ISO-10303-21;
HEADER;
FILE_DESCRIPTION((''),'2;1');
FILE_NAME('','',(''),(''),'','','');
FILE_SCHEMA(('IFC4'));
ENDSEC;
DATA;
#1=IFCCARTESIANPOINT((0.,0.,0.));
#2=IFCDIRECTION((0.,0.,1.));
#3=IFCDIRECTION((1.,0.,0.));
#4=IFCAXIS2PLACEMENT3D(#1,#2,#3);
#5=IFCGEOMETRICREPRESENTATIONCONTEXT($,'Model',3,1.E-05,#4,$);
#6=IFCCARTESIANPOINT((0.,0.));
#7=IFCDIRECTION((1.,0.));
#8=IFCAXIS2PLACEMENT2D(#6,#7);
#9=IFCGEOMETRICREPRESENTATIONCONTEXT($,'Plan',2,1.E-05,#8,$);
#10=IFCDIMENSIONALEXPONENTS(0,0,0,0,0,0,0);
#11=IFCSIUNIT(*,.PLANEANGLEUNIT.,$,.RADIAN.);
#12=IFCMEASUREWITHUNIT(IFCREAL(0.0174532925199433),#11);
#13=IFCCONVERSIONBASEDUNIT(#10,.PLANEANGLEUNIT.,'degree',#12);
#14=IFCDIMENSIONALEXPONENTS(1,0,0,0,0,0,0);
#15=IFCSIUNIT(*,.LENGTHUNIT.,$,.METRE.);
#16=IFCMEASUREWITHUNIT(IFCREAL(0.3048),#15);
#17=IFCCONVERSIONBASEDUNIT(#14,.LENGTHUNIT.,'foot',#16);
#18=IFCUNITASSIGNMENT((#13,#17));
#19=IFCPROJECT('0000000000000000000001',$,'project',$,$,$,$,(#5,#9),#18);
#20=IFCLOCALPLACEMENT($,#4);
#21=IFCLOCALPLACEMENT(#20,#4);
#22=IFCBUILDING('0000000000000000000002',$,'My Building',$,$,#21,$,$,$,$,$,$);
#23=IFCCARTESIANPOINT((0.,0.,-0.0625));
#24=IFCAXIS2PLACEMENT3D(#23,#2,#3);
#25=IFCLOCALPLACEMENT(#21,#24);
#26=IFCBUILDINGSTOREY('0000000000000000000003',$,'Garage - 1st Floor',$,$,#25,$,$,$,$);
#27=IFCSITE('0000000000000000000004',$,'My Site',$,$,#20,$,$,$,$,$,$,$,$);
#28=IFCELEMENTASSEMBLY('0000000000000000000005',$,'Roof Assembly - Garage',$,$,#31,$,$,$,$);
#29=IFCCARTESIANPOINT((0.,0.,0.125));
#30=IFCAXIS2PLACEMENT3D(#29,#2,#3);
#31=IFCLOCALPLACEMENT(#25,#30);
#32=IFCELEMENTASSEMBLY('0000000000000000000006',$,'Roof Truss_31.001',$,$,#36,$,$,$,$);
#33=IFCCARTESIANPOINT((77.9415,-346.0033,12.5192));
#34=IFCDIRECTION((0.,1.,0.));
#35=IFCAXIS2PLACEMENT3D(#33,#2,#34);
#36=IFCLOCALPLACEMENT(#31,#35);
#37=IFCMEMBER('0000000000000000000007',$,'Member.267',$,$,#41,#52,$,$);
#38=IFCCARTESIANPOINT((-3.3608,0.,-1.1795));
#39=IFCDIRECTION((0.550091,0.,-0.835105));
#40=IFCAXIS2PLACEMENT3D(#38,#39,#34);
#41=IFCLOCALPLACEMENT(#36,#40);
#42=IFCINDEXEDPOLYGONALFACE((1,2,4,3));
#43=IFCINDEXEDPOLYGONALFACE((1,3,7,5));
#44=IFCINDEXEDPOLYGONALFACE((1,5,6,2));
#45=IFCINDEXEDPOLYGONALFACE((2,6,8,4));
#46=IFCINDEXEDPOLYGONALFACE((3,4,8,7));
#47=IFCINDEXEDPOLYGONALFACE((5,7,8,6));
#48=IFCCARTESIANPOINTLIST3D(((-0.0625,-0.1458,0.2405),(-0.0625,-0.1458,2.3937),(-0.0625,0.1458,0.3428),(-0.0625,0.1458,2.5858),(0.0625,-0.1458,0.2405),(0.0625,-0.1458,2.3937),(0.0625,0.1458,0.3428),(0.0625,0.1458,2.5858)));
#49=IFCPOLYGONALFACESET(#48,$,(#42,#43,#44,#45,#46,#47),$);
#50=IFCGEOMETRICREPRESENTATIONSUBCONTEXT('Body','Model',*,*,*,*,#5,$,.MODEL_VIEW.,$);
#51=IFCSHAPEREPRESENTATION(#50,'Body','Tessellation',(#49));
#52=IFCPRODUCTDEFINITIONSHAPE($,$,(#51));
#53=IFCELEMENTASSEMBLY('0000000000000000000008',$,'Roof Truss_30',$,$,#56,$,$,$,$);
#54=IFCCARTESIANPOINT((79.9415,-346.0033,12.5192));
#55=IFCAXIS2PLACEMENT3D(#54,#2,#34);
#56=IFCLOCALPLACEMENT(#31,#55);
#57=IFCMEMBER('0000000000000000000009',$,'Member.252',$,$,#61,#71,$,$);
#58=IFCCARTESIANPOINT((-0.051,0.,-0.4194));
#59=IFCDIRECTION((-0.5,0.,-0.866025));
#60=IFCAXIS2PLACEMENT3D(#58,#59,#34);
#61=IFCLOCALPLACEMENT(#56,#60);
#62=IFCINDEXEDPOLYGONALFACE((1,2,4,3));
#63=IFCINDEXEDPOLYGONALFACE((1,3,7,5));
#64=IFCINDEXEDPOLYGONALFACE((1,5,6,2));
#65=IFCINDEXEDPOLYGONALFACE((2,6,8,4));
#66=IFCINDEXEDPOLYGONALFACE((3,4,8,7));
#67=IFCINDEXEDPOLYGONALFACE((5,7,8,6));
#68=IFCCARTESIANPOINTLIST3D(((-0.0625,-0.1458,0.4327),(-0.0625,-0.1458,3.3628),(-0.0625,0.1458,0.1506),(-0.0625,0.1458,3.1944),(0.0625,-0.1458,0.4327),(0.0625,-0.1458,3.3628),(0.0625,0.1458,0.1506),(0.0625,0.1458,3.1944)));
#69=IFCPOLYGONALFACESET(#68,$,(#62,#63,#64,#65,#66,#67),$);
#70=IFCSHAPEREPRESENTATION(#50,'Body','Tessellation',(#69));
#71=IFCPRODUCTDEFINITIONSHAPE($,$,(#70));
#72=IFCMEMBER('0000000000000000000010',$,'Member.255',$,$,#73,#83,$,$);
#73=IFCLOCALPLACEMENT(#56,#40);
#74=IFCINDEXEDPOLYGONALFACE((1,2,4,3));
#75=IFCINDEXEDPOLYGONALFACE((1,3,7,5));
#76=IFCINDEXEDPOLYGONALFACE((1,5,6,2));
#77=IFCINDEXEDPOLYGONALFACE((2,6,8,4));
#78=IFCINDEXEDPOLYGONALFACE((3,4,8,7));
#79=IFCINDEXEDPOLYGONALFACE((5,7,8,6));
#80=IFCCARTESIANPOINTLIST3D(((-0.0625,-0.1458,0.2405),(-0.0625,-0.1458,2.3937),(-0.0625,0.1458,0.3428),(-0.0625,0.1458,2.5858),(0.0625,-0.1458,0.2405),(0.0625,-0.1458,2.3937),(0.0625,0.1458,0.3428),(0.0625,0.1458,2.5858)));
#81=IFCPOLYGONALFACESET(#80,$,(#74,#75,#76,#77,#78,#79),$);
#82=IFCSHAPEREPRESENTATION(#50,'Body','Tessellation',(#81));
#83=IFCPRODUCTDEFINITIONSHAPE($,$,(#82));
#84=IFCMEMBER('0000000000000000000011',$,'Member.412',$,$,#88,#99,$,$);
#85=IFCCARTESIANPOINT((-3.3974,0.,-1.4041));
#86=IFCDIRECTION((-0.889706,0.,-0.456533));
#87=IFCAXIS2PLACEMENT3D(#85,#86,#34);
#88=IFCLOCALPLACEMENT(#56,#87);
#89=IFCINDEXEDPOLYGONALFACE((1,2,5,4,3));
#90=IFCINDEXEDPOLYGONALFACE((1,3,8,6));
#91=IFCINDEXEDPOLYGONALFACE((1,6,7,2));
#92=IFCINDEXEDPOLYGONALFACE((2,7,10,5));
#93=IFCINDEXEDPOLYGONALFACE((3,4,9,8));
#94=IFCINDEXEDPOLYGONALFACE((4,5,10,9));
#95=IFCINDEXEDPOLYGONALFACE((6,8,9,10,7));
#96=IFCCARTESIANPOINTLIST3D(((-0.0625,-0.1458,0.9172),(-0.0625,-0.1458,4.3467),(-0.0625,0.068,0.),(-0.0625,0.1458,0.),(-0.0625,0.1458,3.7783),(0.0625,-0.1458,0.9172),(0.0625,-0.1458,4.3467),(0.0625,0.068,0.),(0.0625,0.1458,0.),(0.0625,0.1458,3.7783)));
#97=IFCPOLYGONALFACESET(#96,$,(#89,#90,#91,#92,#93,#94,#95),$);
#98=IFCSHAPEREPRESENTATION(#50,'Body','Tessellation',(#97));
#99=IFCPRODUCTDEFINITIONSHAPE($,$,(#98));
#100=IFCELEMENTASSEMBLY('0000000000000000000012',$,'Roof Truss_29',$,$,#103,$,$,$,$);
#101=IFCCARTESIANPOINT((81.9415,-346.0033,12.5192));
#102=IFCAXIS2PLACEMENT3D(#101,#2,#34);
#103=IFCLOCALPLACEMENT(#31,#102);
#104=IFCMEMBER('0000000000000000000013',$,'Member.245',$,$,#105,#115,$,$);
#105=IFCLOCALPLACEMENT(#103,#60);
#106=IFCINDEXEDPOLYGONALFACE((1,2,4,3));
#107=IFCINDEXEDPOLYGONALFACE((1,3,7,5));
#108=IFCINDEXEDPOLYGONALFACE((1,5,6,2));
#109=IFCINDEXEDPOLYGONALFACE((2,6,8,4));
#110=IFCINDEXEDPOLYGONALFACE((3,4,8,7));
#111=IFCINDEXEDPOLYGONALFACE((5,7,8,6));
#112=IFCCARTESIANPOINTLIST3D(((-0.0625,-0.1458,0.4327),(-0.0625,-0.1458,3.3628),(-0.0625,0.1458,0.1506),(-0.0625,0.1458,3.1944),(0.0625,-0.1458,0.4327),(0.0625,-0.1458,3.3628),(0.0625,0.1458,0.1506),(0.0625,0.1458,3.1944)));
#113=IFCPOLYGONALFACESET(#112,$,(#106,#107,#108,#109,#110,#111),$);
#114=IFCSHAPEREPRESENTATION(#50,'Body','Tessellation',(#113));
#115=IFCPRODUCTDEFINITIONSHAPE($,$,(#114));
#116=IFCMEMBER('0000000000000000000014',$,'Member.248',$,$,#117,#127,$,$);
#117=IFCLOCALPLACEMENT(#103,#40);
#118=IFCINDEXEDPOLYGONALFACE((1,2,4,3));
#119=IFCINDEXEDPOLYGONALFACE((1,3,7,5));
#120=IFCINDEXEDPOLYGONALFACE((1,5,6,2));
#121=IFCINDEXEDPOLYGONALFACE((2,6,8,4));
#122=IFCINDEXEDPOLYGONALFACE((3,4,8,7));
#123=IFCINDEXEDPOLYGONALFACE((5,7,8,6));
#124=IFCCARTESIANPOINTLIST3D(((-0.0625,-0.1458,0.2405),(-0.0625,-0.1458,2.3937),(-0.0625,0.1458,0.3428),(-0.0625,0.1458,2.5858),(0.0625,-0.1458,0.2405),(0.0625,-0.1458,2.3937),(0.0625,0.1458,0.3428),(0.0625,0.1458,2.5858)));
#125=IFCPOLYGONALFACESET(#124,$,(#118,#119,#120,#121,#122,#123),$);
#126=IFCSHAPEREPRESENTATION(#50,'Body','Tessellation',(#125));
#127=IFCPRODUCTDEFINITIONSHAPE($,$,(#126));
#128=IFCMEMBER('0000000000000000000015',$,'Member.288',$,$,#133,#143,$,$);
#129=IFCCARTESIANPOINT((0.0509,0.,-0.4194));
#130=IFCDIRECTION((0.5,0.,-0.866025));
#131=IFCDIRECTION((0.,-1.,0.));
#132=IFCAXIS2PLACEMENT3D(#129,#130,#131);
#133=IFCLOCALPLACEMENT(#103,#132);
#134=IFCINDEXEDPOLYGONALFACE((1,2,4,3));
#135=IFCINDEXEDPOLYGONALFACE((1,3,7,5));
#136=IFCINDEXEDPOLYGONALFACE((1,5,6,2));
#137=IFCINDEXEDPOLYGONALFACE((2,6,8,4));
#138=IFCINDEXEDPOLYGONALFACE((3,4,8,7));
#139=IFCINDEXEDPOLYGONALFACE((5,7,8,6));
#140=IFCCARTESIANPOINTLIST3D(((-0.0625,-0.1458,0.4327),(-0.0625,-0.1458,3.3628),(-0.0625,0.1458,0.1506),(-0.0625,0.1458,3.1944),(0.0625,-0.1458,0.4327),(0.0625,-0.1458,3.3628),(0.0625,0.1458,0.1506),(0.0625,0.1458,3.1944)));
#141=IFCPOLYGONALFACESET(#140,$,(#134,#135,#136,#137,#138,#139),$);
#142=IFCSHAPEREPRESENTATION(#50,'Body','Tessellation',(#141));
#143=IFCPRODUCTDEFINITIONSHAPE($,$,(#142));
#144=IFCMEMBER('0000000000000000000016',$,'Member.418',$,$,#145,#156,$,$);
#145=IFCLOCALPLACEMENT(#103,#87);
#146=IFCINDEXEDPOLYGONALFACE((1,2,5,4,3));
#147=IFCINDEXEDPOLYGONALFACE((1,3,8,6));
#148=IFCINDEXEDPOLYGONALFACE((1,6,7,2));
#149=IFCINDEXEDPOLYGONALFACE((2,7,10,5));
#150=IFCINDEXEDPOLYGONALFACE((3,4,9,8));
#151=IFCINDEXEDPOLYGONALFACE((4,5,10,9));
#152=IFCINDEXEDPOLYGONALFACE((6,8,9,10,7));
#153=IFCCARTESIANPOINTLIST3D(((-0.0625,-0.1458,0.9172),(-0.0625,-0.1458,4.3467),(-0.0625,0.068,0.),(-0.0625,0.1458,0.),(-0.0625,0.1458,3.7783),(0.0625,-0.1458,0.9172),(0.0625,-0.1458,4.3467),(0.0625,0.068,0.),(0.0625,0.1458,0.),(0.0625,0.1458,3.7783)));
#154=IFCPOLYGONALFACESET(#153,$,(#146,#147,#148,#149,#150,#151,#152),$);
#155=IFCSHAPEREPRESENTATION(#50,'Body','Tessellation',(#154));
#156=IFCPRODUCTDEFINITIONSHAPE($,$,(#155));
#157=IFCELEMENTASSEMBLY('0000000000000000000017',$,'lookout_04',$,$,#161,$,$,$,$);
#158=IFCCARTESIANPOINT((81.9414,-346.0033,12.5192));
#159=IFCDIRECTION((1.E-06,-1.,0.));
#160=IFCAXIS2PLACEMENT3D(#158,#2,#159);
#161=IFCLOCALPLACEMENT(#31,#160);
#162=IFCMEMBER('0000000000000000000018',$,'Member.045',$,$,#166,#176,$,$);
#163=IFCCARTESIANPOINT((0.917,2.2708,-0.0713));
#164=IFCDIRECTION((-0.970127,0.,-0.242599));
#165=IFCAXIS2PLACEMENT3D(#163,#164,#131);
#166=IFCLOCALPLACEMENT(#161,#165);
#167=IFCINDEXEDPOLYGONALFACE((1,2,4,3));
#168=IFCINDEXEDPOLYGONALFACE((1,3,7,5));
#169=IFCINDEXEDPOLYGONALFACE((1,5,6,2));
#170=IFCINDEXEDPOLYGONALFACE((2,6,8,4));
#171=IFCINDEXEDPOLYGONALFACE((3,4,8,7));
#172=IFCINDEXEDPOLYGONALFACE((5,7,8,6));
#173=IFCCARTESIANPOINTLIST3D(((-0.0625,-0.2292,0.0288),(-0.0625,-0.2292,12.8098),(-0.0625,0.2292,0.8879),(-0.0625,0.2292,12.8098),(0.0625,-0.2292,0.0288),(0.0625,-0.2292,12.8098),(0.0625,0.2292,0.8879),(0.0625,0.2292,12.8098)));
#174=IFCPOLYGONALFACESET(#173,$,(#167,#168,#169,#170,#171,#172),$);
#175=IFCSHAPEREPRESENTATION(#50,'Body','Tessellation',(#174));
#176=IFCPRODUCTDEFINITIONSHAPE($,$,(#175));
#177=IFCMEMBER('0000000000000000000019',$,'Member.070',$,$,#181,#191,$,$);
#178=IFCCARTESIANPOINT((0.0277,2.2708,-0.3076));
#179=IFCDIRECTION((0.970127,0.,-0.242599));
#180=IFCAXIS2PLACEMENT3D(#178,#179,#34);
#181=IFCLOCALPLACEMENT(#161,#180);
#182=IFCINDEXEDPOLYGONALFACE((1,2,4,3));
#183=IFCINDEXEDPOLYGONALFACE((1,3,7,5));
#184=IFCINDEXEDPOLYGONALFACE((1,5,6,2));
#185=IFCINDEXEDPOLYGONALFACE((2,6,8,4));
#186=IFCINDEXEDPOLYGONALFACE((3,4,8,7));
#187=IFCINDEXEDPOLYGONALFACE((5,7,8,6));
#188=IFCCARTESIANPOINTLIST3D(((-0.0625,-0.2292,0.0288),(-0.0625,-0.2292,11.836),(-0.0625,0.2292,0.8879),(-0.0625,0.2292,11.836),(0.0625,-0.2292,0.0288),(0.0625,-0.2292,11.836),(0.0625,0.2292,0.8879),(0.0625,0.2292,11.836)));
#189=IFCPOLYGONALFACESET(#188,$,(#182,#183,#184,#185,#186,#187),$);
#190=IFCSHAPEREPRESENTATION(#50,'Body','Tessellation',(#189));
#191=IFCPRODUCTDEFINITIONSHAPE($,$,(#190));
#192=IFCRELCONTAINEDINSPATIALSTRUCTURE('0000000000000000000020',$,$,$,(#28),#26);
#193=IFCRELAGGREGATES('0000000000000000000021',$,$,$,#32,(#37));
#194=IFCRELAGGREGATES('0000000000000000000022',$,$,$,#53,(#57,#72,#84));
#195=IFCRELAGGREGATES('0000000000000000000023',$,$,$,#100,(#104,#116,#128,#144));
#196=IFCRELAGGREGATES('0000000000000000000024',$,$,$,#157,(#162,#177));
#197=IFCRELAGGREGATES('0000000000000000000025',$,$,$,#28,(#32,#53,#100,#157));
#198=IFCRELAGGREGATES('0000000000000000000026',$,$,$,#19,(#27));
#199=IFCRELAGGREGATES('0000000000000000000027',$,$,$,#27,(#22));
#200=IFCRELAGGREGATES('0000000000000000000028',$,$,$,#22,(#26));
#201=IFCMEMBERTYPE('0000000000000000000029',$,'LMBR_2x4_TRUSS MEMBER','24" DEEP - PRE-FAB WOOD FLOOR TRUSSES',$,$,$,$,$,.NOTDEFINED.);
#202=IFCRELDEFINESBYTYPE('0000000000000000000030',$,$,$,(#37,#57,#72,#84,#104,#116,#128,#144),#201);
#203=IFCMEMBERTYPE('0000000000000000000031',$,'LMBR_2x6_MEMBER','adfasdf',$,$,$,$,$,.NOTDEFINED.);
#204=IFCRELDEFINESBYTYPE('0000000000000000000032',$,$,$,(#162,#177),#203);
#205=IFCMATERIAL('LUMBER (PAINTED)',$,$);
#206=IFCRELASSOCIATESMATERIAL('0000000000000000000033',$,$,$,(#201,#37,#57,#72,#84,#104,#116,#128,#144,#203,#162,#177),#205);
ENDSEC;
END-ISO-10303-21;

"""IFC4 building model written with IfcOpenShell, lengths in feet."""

from ifc_helpers import new_model, entity, si_unit, converted_unit, frame, origin_with_axes, origin_2d_with_axis, place, context, subcontext, project, spatial, indexed_curve, outline, extrude, clip, halfspace, material, material_profile, profile_set, profile_usage, type_object, element, aggregate, save


model = new_model("IFC4")

# Units and contexts
model_context = context("Model", 3, precision=1e-05, world=origin_with_axes())
plan_context = context("Plan", 2, precision=1e-05, world=origin_2d_with_axis())
body_context = subcontext(model_context, "Body", "Model", "MODEL_VIEW")
ifc_project = project(units=[converted_unit("PLANEANGLEUNIT", "degree", entity("IfcReal", 0.0174532925199433), si_unit("PLANEANGLEUNIT", "RADIAN"), dimensions=[0, 0, 0, 0, 0, 0, 0]), converted_unit("LENGTHUNIT", "foot", entity("IfcReal", 0.3048), si_unit("LENGTHUNIT", "METRE"), dimensions=[1, 0, 0, 0, 0, 0, 0])], contexts=[model_context, plan_context])

# Site, building, storey
site_placement = place(None, origin_with_axes())
site = spatial("IfcSite", under=ifc_project, at=site_placement, Name="My Site")
building_placement = place(site_placement, origin_with_axes())
building = spatial("IfcBuilding", under=site, at=building_placement, Name="My Building")
storey_placement = place(building_placement, frame((0.0, 0.0, -0.0625), z_axis=(0.0, 0.0, 1.0), x_axis=(1.0, 0.0, 0.0)))
storey = spatial("IfcBuildingStorey", under=building, at=storey_placement, Name="Garage - 1st Floor")

# Element assemblies, members
assembly_1_placement = place(storey_placement, frame((0.0, 0.0, 0.125), z_axis=(0.0, 0.0, 1.0), x_axis=(1.0, 0.0, 0.0)))
assembly_1 = element("IfcElementAssembly", 1, at=assembly_1_placement, inside=storey, Name="Roof Assembly - Garage")
assembly_2_placement = place(assembly_1_placement, frame((77.9415, -346.0033, 12.5192), z_axis=(0.0, 0.0, 1.0), x_axis=(0.0, 1.0, 0.0)))
assembly_2 = element("IfcElementAssembly", 2, at=assembly_2_placement, Name="Roof Truss_31.001")
ifc_material_1 = material(Name="LUMBER (PAINTED)")
ifc_material_profile_1 = material_profile(ifc_material_1, outline(indexed_curve([(-0.0625, -0.1458), (0.0625, -0.1458), (0.0625, 0.1458), (-0.0625, 0.1458), (-0.0625, -0.1458)])))
ifc_profile_set_1 = profile_set([ifc_material_profile_1])
ifc_profile_usage_1 = profile_usage(ifc_profile_set_1)
member_type_1 = type_object("IfcMemberType", Name="LMBR_2x4_TRUSS MEMBER", Description="24\" DEEP - PRE-FAB WOOD FLOOR TRUSSES", PredefinedType="NOTDEFINED", material=ifc_profile_set_1)
member_1_placement = place(assembly_2_placement, frame((-3.3608, 0.0, -1.1795), z_axis=(0.550091, 0.0, -0.835105), x_axis=(0.0, 1.0, 0.0)))
member_1 = element("IfcMember", 3, at=member_1_placement, type_object=member_type_1, material=ifc_profile_usage_1, Name="Member.267", context=body_context, shape_type="Clipping", body=[
    clip(clip(extrude(outline(indexed_curve([(-0.0625, -0.1458), (0.0625, -0.1458), (0.0625, 0.1458), (-0.0625, 0.1458), (-0.0625, -0.1458)])), origin_with_axes(), (0.0, 0.0, 1.0), 2.7815), halfspace(frame((0.0, 3.2555, 1.4338), z_axis=(0.0, 0.331063, -0.943609), x_axis=(1.0, 0.0, 0.0)), False)), halfspace(frame((0.0, 7.9609, 7.7337), z_axis=(0.0, -0.550091, 0.835105), x_axis=(-1.0, 0.0, 0.0)), False)),
])
aggregate(assembly_2, [member_1])
assembly_3_placement = place(assembly_1_placement, frame((79.9415, -346.0033, 12.5192), z_axis=(0.0, 0.0, 1.0), x_axis=(0.0, 1.0, 0.0)))
assembly_3 = element("IfcElementAssembly", 4, at=assembly_3_placement, Name="Roof Truss_30")
ifc_profile_usage_2 = profile_usage(ifc_profile_set_1)
member_2_placement = place(assembly_3_placement, frame((-0.051, 0.0, -0.4194), z_axis=(-0.5, 0.0, -0.866025), x_axis=(0.0, 1.0, 0.0)))
member_2 = element("IfcMember", 5, at=member_2_placement, type_object=member_type_1, material=ifc_profile_usage_2, Name="Member.252", context=body_context, shape_type="Clipping", body=[
    clip(clip(extrude(outline(indexed_curve([(-0.0625, -0.1458), (0.0625, -0.1458), (0.0625, 0.1458), (-0.0625, 0.1458), (-0.0625, -0.1458)])), origin_with_axes(), (0.0, 0.0, 1.0), 3.5703), halfspace(frame((0.0, 0.2544, 0.0456), z_axis=(0.0, -0.69516, -0.718855), x_axis=(-1.0, 0.000001, 0.0)), False)), halfspace(frame((0.0, 7.9951, -1.3373), z_axis=(0.0, 0.5, 0.866026), x_axis=(1.0, 0.0, 0.0)), False)),
])
ifc_profile_usage_3 = profile_usage(ifc_profile_set_1)
member_3_placement = place(assembly_3_placement, frame((-3.3608, 0.0, -1.1795), z_axis=(0.550091, 0.0, -0.835105), x_axis=(0.0, 1.0, 0.0)))
member_3 = element("IfcMember", 6, at=member_3_placement, type_object=member_type_1, material=ifc_profile_usage_3, Name="Member.255", context=body_context, shape_type="Clipping", body=[
    clip(clip(extrude(outline(indexed_curve([(-0.0625, -0.1458), (0.0625, -0.1458), (0.0625, 0.1458), (-0.0625, 0.1458), (-0.0625, -0.1458)])), origin_with_axes(), (0.0, 0.0, 1.0), 2.7815), halfspace(frame((0.0, 3.2555, 1.4338), z_axis=(0.0, 0.331063, -0.943609), x_axis=(1.0, 0.0, 0.0)), False)), halfspace(frame((0.0, 7.9609, 7.7337), z_axis=(0.0, -0.550091, 0.835105), x_axis=(-1.0, 0.0, 0.0)), False)),
])
ifc_profile_usage_4 = profile_usage(ifc_profile_set_1)
member_4_placement = place(assembly_3_placement, frame((-3.3974, 0.0, -1.4041), z_axis=(-0.889706, 0.0, -0.456533), x_axis=(0.0, 1.0, 0.0)))
member_4 = element("IfcMember", 7, at=member_4_placement, type_object=member_type_1, material=ifc_profile_usage_4, Name="Member.412", context=body_context, shape_type="Clipping", body=[
    clip(clip(extrude(outline(indexed_curve([(-0.0625, -0.1458), (0.0625, -0.1458), (0.0625, 0.1458), (-0.0625, 0.1458), (-0.0625, -0.1458)])), origin_with_axes(), (0.0, 0.0, 1.0), 4.3542), halfspace(frame((0.0, 6.6441, -8.8858), z_axis=(0.0, 0.889707, 0.456533), x_axis=(1.0, 0.0, 0.0)), False)), halfspace(frame((0.0, 0.8902, -3.5265), z_axis=(-0.000001, -0.973882, -0.227053), x_axis=(-1.0, 0.000001, 0.0)), False)),
])
assembly_4_placement = place(assembly_1_placement, frame((81.9415, -346.0033, 12.5192), z_axis=(0.0, 0.0, 1.0), x_axis=(0.0, 1.0, 0.0)))
assembly_4 = element("IfcElementAssembly", 8, at=assembly_4_placement, Name="Roof Truss_29")
ifc_profile_usage_5 = profile_usage(ifc_profile_set_1)
member_5_placement = place(assembly_4_placement, frame((-0.051, 0.0, -0.4194), z_axis=(-0.5, 0.0, -0.866025), x_axis=(0.0, 1.0, 0.0)))
member_5 = element("IfcMember", 9, at=member_5_placement, type_object=member_type_1, material=ifc_profile_usage_5, Name="Member.245", context=body_context, shape_type="Clipping", body=[
    clip(clip(extrude(outline(indexed_curve([(-0.0625, -0.1458), (0.0625, -0.1458), (0.0625, 0.1458), (-0.0625, 0.1458), (-0.0625, -0.1458)])), origin_with_axes(), (0.0, 0.0, 1.0), 3.5703), halfspace(frame((0.0, 0.2544, 0.0456), z_axis=(0.0, -0.69516, -0.718855), x_axis=(-1.0, 0.000001, 0.0)), False)), halfspace(frame((0.0, 7.9951, -1.3373), z_axis=(0.0, 0.5, 0.866026), x_axis=(1.0, 0.0, 0.0)), False)),
])
ifc_profile_usage_6 = profile_usage(ifc_profile_set_1)
member_6_placement = place(assembly_4_placement, frame((-3.3608, 0.0, -1.1795), z_axis=(0.550091, 0.0, -0.835105), x_axis=(0.0, 1.0, 0.0)))
member_6 = element("IfcMember", 10, at=member_6_placement, type_object=member_type_1, material=ifc_profile_usage_6, Name="Member.248", context=body_context, shape_type="Clipping", body=[
    clip(clip(extrude(outline(indexed_curve([(-0.0625, -0.1458), (0.0625, -0.1458), (0.0625, 0.1458), (-0.0625, 0.1458), (-0.0625, -0.1458)])), origin_with_axes(), (0.0, 0.0, 1.0), 2.7815), halfspace(frame((0.0, 3.2555, 1.4338), z_axis=(0.0, 0.331063, -0.943609), x_axis=(1.0, 0.0, 0.0)), False)), halfspace(frame((0.0, 7.9609, 7.7337), z_axis=(0.0, -0.550091, 0.835105), x_axis=(-1.0, 0.0, 0.0)), False)),
])
ifc_profile_usage_7 = profile_usage(ifc_profile_set_1)
member_7_placement = place(assembly_4_placement, frame((0.0509, 0.0, -0.4194), z_axis=(0.5, 0.0, -0.866025), x_axis=(0.0, -1.0, 0.0)))
member_7 = element("IfcMember", 11, at=member_7_placement, type_object=member_type_1, material=ifc_profile_usage_7, Name="Member.288", context=body_context, shape_type="Clipping", body=[
    clip(clip(extrude(outline(indexed_curve([(-0.0625, -0.1458), (0.0625, -0.1458), (0.0625, 0.1458), (-0.0625, 0.1458), (-0.0625, -0.1458)])), origin_with_axes(), (0.0, 0.0, 1.0), 3.5703), halfspace(frame((0.0, -5.0674, 6.2043), z_axis=(0.0, 0.5, 0.866025), x_axis=(1.0, 0.0, 0.0)), False)), halfspace(frame((0.0, 0.2544, 0.0456), z_axis=(0.0, -0.695161, -0.718855), x_axis=(-1.0, 0.0, 0.0)), False)),
])
ifc_profile_usage_8 = profile_usage(ifc_profile_set_1)
member_8_placement = place(assembly_4_placement, frame((-3.3974, 0.0, -1.4041), z_axis=(-0.889706, 0.0, -0.456533), x_axis=(0.0, 1.0, 0.0)))
member_8 = element("IfcMember", 12, at=member_8_placement, type_object=member_type_1, material=ifc_profile_usage_8, Name="Member.418", context=body_context, shape_type="Clipping", body=[
    clip(clip(extrude(outline(indexed_curve([(-0.0625, -0.1458), (0.0625, -0.1458), (0.0625, 0.1458), (-0.0625, 0.1458), (-0.0625, -0.1458)])), origin_with_axes(), (0.0, 0.0, 1.0), 4.3542), halfspace(frame((0.0, 6.6441, -8.8858), z_axis=(0.0, 0.889707, 0.456533), x_axis=(1.0, 0.0, 0.0)), False)), halfspace(frame((0.0, 0.8902, -3.5265), z_axis=(-0.000001, -0.973882, -0.227053), x_axis=(-1.0, 0.000001, 0.0)), False)),
])
assembly_5_placement = place(assembly_1_placement, frame((81.9414, -346.0033, 12.5192), z_axis=(0.0, 0.0, 1.0), x_axis=(0.000001, -1.0, 0.0)))
assembly_5 = element("IfcElementAssembly", 13, at=assembly_5_placement, Name="lookout_04")
ifc_material_profile_2 = material_profile(ifc_material_1, outline(indexed_curve([(-0.0625, 0.2292), (0.0625, 0.2292), (0.0625, -0.2292), (-0.0625, -0.2292), (-0.0625, 0.2292)])))
ifc_profile_set_2 = profile_set([ifc_material_profile_2])
ifc_profile_usage_9 = profile_usage(ifc_profile_set_2)
member_type_2 = type_object("IfcMemberType", Name="LMBR_2x6_MEMBER", Description="adfasdf", PredefinedType="NOTDEFINED", material=ifc_profile_set_2)
member_9_placement = place(assembly_5_placement, frame((0.917, 2.2708, -0.0713), z_axis=(-0.970127, 0.0, -0.242599), x_axis=(0.0, -1.0, 0.0)))
member_9 = element("IfcMember", 14, at=member_9_placement, type_object=member_type_2, material=ifc_profile_usage_9, Name="Member.045", context=body_context, shape_type="Clipping", body=[
    clip(extrude(outline(indexed_curve([(-0.0625, 0.2292), (0.0625, 0.2292), (0.0625, -0.2292), (-0.0625, -0.2292), (-0.0625, 0.2292)])), origin_with_axes(), (0.0, 0.0, 1.0), 12.8098), halfspace(frame((0.0, 0.1888, 0.8122), z_axis=(0.0, 0.882291, -0.470704), x_axis=(1.0, 0.0, 0.0)), False)),
])
ifc_profile_usage_10 = profile_usage(ifc_profile_set_2)
member_10_placement = place(assembly_5_placement, frame((0.0277, 2.2708, -0.3076), z_axis=(0.970127, 0.0, -0.242599), x_axis=(0.0, 1.0, 0.0)))
member_10 = element("IfcMember", 15, at=member_10_placement, type_object=member_type_2, material=ifc_profile_usage_10, Name="Member.070", context=body_context, shape_type="Clipping", body=[
    clip(extrude(outline(indexed_curve([(-0.0625, 0.2292), (0.0625, 0.2292), (0.0625, -0.2292), (-0.0625, -0.2292), (-0.0625, 0.2292)])), origin_with_axes(), (0.0, 0.0, 1.0), 11.836), halfspace(frame((0.0, 0.2427, 0.9133), z_axis=(0.0, 0.882291, -0.470704), x_axis=(1.0, 0.0, 0.0)), False)),
])
aggregate(assembly_3, [member_2, member_3, member_4])
aggregate(assembly_4, [member_5, member_6, member_7, member_8])
aggregate(assembly_5, [member_9, member_10])
aggregate(assembly_1, [assembly_2, assembly_3, assembly_4, assembly_5])

save(model, "model.ifc")
